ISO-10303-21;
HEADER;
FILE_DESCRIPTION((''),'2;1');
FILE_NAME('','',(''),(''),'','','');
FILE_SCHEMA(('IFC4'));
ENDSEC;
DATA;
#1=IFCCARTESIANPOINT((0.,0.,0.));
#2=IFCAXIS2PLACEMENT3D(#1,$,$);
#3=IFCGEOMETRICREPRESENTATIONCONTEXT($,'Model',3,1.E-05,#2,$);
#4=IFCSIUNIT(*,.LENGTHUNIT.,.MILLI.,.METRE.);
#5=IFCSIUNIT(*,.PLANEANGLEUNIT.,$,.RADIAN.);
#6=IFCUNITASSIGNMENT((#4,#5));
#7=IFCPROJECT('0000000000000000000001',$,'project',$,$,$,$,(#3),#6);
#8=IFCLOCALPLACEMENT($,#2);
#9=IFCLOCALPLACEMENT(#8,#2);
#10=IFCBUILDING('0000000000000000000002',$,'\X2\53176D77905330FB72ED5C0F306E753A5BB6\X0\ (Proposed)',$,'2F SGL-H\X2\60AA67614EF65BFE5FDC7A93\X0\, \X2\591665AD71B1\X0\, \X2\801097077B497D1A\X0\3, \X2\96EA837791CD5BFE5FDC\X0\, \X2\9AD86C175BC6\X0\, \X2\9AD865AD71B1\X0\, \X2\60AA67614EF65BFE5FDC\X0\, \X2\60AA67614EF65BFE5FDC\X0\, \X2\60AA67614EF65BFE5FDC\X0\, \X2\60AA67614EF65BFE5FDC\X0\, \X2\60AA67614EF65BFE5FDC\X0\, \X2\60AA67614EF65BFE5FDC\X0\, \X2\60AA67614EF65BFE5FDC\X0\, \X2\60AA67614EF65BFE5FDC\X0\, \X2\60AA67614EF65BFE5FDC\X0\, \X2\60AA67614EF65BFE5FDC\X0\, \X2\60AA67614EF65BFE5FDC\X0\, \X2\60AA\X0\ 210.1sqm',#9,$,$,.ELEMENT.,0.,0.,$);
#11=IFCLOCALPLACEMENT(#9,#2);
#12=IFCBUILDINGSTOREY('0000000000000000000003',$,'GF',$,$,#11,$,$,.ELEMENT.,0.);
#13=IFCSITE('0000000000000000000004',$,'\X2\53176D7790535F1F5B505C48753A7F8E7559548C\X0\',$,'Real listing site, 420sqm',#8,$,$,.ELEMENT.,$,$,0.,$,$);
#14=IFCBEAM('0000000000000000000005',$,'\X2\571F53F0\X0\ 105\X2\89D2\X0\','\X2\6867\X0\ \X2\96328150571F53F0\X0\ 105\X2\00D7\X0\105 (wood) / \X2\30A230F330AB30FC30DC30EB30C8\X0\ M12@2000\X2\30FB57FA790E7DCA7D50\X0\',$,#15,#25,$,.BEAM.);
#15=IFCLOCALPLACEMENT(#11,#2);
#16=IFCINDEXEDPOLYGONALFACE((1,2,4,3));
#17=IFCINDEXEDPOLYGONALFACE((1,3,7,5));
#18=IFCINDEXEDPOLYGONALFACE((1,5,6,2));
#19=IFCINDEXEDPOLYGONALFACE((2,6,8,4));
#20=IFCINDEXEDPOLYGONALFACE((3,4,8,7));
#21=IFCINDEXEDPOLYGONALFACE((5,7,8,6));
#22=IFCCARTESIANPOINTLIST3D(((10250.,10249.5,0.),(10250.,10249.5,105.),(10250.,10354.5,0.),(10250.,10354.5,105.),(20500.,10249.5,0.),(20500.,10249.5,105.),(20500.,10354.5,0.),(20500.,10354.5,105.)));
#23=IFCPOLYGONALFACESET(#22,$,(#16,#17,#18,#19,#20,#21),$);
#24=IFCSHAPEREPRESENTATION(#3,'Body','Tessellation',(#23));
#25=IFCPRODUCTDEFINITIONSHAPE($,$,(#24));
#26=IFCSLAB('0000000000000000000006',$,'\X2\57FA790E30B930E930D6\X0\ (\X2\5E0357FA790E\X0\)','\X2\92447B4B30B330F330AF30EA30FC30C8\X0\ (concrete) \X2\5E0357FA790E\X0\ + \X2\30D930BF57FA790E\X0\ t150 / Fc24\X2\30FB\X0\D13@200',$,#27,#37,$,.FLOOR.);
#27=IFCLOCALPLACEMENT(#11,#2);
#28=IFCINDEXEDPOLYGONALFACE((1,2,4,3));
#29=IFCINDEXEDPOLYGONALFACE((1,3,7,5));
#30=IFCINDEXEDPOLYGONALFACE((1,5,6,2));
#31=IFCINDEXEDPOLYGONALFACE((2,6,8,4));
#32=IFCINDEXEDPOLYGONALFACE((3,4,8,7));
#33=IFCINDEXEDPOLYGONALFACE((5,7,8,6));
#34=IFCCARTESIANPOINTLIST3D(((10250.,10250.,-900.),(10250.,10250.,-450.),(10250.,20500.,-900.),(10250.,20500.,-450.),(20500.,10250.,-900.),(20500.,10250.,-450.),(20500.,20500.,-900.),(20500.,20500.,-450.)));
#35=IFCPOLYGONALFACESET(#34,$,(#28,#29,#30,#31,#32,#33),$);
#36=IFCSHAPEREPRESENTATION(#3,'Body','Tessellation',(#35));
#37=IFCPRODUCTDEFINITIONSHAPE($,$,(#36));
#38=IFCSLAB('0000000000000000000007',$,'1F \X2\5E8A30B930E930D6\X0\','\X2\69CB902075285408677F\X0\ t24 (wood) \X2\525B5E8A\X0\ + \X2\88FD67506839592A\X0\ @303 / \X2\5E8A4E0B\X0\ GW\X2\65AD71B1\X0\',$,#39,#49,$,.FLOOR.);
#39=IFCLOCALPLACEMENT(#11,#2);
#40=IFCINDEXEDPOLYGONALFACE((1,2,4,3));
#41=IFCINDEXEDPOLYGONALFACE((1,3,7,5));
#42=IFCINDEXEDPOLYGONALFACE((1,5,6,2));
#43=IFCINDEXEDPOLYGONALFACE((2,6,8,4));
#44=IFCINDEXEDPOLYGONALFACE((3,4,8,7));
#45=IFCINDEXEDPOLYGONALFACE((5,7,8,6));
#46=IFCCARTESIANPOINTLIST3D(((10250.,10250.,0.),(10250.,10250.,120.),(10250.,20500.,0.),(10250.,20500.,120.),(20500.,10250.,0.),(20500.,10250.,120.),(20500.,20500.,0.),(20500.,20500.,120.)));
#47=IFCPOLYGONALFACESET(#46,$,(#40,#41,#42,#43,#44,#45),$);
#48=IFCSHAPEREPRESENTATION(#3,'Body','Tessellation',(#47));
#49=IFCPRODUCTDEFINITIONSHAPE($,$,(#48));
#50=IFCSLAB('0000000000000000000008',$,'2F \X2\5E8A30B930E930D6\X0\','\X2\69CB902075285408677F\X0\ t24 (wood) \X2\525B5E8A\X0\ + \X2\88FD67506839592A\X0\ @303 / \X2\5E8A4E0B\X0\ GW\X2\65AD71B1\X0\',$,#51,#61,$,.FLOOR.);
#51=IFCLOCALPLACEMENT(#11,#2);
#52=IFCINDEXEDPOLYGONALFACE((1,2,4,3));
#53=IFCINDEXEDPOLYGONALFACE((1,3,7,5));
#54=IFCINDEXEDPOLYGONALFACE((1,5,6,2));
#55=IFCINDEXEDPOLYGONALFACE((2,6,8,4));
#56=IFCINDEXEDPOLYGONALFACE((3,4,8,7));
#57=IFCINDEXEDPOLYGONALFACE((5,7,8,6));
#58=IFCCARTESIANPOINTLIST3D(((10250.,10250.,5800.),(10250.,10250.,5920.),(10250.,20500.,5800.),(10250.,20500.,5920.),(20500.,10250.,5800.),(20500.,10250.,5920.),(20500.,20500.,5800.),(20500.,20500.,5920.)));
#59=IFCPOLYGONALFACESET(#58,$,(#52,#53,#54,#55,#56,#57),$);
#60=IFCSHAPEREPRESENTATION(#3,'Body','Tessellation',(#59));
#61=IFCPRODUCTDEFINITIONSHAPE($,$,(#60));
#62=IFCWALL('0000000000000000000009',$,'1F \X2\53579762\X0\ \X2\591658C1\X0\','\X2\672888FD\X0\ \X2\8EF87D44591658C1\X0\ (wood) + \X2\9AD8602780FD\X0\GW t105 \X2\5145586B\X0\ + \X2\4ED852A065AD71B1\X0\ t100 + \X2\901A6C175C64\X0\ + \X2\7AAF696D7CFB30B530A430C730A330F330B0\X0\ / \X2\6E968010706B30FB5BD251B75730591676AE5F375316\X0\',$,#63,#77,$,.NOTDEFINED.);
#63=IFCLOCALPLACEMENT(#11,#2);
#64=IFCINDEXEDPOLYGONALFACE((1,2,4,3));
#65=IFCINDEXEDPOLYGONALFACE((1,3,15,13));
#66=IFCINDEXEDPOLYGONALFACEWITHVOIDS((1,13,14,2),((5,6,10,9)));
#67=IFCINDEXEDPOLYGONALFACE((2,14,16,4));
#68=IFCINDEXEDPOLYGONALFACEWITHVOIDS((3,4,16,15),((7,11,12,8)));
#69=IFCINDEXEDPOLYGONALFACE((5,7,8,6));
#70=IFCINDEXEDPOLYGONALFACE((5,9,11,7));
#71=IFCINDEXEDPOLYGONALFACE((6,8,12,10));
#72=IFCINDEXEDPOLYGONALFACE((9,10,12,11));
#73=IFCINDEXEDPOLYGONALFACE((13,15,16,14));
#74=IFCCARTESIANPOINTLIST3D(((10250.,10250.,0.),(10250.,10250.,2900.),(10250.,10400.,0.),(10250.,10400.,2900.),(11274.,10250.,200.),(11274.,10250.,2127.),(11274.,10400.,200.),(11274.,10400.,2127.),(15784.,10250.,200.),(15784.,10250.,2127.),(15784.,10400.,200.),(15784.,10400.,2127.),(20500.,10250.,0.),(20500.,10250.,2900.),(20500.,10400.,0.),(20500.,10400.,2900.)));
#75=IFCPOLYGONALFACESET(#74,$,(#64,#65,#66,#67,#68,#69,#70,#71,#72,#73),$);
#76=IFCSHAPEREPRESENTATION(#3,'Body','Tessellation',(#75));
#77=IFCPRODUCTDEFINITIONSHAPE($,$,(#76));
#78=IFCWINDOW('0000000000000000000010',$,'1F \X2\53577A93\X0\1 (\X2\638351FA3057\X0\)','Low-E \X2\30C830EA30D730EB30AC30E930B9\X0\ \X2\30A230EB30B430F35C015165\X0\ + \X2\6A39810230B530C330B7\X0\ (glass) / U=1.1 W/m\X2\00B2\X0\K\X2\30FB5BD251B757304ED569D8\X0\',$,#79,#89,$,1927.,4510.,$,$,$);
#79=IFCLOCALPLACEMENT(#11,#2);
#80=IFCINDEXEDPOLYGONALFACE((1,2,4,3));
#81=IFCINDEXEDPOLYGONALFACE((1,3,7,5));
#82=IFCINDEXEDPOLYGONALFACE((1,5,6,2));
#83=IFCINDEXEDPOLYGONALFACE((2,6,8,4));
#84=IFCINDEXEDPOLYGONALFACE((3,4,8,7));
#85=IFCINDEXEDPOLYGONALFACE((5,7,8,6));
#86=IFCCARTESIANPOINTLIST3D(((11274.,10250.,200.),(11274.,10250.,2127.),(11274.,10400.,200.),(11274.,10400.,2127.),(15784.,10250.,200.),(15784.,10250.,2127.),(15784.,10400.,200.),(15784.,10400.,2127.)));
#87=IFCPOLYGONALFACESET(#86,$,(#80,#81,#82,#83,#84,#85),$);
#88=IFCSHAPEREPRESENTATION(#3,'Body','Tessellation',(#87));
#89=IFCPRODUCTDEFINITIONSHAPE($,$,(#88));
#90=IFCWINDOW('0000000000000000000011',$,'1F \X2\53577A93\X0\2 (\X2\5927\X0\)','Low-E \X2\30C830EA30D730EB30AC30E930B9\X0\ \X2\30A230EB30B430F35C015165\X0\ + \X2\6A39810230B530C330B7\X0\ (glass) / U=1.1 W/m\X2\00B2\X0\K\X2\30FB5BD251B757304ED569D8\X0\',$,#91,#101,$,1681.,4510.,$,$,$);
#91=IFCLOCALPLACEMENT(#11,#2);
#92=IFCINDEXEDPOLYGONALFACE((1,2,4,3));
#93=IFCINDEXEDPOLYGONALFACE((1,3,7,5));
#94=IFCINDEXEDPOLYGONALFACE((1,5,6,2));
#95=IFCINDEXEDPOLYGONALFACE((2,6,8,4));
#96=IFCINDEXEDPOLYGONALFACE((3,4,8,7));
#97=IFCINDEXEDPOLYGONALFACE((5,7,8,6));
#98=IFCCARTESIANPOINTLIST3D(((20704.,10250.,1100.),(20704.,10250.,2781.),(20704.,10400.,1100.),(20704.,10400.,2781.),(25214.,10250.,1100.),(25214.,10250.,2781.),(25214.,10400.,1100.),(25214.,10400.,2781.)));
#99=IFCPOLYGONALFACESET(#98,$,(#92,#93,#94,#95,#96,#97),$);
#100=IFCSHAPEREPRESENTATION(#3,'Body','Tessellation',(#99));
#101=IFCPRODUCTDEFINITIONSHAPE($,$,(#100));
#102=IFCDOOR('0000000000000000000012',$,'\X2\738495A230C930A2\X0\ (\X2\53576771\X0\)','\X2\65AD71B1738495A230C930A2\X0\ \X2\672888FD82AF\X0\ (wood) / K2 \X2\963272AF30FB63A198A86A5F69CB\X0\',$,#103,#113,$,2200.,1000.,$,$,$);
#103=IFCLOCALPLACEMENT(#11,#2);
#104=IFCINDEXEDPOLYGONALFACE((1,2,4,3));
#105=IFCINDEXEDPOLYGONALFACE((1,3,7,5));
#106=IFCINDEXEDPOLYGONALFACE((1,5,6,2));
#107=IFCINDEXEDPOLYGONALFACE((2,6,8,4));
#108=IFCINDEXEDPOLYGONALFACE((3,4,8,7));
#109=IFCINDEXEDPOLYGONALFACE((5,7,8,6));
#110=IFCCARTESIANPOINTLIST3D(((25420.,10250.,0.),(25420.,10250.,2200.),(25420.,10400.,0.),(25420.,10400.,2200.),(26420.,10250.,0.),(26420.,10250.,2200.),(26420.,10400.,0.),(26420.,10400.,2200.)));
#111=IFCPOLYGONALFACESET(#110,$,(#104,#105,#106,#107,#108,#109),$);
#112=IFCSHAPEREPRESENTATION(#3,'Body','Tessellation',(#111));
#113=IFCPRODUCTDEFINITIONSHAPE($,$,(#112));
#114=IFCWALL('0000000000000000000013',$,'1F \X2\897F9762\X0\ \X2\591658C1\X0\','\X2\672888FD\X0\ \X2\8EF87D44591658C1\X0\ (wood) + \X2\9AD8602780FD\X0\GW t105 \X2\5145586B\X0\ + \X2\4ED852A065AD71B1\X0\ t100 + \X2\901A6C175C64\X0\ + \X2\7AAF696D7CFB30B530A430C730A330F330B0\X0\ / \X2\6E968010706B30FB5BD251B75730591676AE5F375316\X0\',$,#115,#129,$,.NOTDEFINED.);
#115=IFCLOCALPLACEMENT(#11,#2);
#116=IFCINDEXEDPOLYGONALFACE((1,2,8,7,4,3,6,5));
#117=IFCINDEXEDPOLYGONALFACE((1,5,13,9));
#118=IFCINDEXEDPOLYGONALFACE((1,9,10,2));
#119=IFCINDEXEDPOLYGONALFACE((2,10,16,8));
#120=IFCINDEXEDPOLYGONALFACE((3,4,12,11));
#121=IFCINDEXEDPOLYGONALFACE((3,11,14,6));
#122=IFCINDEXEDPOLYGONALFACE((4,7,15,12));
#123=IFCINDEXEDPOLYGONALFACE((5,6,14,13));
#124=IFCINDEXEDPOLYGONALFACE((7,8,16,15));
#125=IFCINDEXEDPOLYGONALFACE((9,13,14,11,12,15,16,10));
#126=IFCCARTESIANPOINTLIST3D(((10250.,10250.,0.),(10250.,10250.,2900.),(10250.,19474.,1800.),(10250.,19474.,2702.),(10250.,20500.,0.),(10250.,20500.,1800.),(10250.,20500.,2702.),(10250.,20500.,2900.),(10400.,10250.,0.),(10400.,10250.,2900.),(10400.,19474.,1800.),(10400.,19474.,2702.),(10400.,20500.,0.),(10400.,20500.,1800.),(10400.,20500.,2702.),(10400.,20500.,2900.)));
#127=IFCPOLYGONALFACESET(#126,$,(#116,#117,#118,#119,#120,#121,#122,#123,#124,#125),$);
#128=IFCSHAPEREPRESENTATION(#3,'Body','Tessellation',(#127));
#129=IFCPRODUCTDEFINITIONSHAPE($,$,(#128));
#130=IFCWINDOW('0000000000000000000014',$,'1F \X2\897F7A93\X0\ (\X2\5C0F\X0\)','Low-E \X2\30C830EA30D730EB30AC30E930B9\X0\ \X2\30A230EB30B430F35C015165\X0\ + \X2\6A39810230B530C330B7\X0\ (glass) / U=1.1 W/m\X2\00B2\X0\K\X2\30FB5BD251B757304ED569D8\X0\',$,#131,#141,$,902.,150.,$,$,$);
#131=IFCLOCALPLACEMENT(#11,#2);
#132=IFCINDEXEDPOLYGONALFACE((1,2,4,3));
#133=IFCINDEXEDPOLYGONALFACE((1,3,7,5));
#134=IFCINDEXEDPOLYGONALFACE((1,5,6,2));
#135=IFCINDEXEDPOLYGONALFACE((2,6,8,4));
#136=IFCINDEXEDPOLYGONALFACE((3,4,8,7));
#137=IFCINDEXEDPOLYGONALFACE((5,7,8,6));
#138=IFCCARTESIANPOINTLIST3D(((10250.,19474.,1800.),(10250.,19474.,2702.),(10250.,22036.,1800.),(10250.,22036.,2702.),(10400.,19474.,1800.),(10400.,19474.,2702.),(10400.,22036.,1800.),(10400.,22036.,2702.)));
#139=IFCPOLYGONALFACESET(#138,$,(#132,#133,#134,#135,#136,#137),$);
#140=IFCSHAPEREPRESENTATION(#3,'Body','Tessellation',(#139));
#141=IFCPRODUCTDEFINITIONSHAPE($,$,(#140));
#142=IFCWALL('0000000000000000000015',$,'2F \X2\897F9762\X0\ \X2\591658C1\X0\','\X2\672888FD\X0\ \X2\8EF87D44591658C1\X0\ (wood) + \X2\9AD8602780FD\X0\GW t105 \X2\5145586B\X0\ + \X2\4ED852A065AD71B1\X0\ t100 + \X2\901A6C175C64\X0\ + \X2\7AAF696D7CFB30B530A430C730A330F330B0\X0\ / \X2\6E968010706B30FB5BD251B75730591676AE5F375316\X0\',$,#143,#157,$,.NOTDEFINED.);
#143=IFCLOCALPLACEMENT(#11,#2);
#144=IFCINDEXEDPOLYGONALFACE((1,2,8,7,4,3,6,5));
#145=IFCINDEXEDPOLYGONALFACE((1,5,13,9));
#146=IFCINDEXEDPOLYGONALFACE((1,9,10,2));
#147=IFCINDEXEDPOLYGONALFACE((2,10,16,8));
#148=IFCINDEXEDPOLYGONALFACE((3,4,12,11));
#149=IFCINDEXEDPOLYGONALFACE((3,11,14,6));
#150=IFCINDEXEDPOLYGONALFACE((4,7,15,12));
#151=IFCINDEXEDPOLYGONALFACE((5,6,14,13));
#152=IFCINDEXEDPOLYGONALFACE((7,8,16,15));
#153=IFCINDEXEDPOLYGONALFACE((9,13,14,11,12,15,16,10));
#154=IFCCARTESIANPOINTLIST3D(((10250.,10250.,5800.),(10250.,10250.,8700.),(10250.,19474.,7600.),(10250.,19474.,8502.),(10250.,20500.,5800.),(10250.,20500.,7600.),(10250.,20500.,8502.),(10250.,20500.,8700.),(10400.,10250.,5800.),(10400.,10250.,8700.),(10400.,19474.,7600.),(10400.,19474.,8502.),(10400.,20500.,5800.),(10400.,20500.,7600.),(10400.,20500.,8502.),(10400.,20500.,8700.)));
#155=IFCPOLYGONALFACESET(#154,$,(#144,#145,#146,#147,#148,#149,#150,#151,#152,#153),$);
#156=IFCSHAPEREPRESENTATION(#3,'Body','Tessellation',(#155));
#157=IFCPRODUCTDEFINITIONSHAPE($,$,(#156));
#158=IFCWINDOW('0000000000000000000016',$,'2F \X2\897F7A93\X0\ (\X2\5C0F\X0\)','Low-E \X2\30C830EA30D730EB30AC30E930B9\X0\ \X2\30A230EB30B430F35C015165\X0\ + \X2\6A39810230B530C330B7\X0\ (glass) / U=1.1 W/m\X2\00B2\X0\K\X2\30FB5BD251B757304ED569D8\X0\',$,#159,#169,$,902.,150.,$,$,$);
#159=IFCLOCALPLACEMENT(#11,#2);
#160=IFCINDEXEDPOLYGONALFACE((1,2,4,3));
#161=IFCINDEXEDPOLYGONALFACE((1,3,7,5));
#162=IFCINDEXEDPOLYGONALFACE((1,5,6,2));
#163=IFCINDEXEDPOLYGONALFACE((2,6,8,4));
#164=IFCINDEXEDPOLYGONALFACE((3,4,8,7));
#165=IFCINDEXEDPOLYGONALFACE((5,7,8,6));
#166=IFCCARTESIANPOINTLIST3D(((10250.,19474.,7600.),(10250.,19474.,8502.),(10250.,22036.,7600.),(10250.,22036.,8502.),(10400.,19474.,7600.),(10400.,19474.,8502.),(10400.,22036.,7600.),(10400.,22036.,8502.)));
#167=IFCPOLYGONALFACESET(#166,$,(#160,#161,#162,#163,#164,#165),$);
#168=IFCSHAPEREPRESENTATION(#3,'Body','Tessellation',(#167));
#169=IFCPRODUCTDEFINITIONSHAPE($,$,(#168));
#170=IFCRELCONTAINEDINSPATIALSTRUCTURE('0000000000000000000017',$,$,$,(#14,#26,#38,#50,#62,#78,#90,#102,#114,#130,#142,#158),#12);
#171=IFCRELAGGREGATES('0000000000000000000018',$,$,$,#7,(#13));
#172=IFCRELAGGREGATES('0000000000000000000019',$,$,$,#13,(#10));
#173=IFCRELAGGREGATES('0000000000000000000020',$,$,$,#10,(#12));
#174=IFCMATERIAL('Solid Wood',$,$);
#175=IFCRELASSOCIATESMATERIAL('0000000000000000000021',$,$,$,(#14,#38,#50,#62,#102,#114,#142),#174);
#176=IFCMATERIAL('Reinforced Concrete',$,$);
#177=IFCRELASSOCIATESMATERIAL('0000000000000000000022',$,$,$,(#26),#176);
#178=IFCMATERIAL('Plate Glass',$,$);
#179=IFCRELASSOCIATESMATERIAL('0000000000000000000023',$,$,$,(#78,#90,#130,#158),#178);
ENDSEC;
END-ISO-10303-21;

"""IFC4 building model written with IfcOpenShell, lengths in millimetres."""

from ifc_helpers import new_model, si_unit, frame, frame_2d, origin, place, context, project, spatial, rectangle, extrude, material, element, fill, save


model = new_model("IFC4")

# Units and contexts
model_context = context("Model", 3, precision=1e-05, world=origin())
ifc_project = project(units=[si_unit("LENGTHUNIT", "METRE", prefix="MILLI"), si_unit("PLANEANGLEUNIT", "RADIAN")], contexts=[model_context])

# Site, building, storey
site_placement = place(None, origin())
site = spatial("IfcSite", under=ifc_project, at=site_placement, Name="北海道弟子屈町美留和", ObjectType="Real listing site, 420sqm", CompositionType="ELEMENT", RefElevation=0.0)
building_placement = place(site_placement, origin())
building = spatial("IfcBuilding", under=site, at=building_placement, Name="北海道・狭小の町家 (Proposed)", ObjectType="2F SGL-H悪条件対応窓, 外断熱, 耐震等級3, 雪荷重対応, 高気密, 高断熱, 悪条件対応, 悪条件対応, 悪条件対応, 悪条件対応, 悪条件対応, 悪条件対応, 悪条件対応, 悪条件対応, 悪条件対応, 悪条件対応, 悪条件対応, 悪 210.1sqm", CompositionType="ELEMENT", ElevationOfRefHeight=0.0, ElevationOfTerrain=0.0)
storey_placement = place(building_placement, origin())
storey = spatial("IfcBuildingStorey", under=building, at=storey_placement, Name="GF", CompositionType="ELEMENT", Elevation=0.0)

# Shared definitions
ifc_material_1 = material(Name="Solid Wood")

# Beam
beam_placement = place(storey_placement, frame((5125.0, 5125.0, 0.0)))
element("IfcBeam", 1, at=beam_placement, inside=storey, material=ifc_material_1, Name="土台 105角", Description="桧 防腐土台 105×105 (wood) / アンカーボルト M12@2000・基礎緊結", PredefinedType="BEAM", context=model_context, shape_type="SweptSolid", body=[
    extrude(rectangle(XDim=10250.0, YDim=105.0, at=frame_2d((5125.0, 52.0))), frame((5125.0, 5125.0, 0.0)), (0.0, 0.0, 1.0), 105.0),
])

# Slabs
ifc_material_2 = material(Name="Reinforced Concrete")
slab_1_placement = place(storey_placement, frame((5125.0, 5125.0, -450.0)))
element("IfcSlab", 2, at=slab_1_placement, inside=storey, material=ifc_material_2, Name="基礎スラブ (布基礎)", Description="鉄筋コンクリート (concrete) 布基礎 + ベタ基礎 t150 / Fc24・D13@200", PredefinedType="FLOOR", context=model_context, shape_type="SweptSolid", body=[
    extrude(rectangle(XDim=10250.0, YDim=10250.0, at=frame_2d((5125.0, 5125.0))), frame((5125.0, 5125.0, -450.0)), (0.0, 0.0, 1.0), 450.0),
])
slab_2_placement = place(storey_placement, frame((5125.0, 5125.0, 0.0)))
element("IfcSlab", 3, at=slab_2_placement, inside=storey, material=ifc_material_1, Name="1F 床スラブ", Description="構造用合板 t24 (wood) 剛床 + 製材根太 @303 / 床下 GW断熱", PredefinedType="FLOOR", context=model_context, shape_type="SweptSolid", body=[
    extrude(rectangle(XDim=10250.0, YDim=10250.0, at=frame_2d((5125.0, 5125.0))), frame((5125.0, 5125.0, 0.0)), (0.0, 0.0, 1.0), 120.0),
])
slab_3_placement = place(storey_placement, frame((5125.0, 5125.0, 2900.0)))
element("IfcSlab", 4, at=slab_3_placement, inside=storey, material=ifc_material_1, Name="2F 床スラブ", Description="構造用合板 t24 (wood) 剛床 + 製材根太 @303 / 床下 GW断熱", PredefinedType="FLOOR", context=model_context, shape_type="SweptSolid", body=[
    extrude(rectangle(XDim=10250.0, YDim=10250.0, at=frame_2d((5125.0, 5125.0))), frame((5125.0, 5125.0, 2900.0)), (0.0, 0.0, 1.0), 120.0),
])

# Wall, openings, windows, door
wall_1_placement = place(storey_placement, frame((5125.0, 5125.0, 0.0)))
wall_1 = element("IfcWall", 5, at=wall_1_placement, inside=storey, material=ifc_material_1, Name="1F 南面 外壁", Description="木製 軸組外壁 (wood) + 高性能GW t105 充填 + 付加断熱 t100 + 通気層 + 窯業系サイディング / 準耐火・寒冷地外皮強化", PredefinedType="NOTDEFINED", context=model_context, shape_type="SweptSolid", body=[
    extrude(rectangle(XDim=10250.0, YDim=150.0, at=frame_2d((5125.0, 75.0))), frame((5125.0, 5125.0, 0.0)), (0.0, 0.0, 1.0), 2900.0),
])
opening_1_placement = place(storey_placement, frame((5637.0, 5125.0, 100.0)))
opening_1 = element("IfcOpeningElement", 6, at=opening_1_placement, cuts=wall_1, PredefinedType="NOTDEFINED", context=model_context, shape_type="SweptSolid", body=[
    extrude(rectangle(XDim=4510.0, YDim=150.0, at=frame_2d((2255.0, 75.0))), frame((5637.0, 5125.0, 100.0)), (0.0, 0.0, 1.0), 1927.0),
])
opening_2_placement = place(storey_placement, frame((10352.0, 5125.0, 550.0)))
opening_2 = element("IfcOpeningElement", 7, at=opening_2_placement, cuts=wall_1, PredefinedType="NOTDEFINED", context=model_context, shape_type="SweptSolid", body=[
    extrude(rectangle(XDim=4510.0, YDim=150.0, at=frame_2d((2255.0, 75.0))), frame((10352.0, 5125.0, 550.0)), (0.0, 0.0, 1.0), 1681.0),
])
opening_3_placement = place(storey_placement, frame((12710.0, 5125.0, 0.0)))
opening_3 = element("IfcOpeningElement", 8, at=opening_3_placement, cuts=wall_1, PredefinedType="NOTDEFINED", context=model_context, shape_type="SweptSolid", body=[
    extrude(rectangle(XDim=1000.0, YDim=150.0, at=frame_2d((500.0, 75.0))), frame((12710.0, 5125.0, 0.0)), (0.0, 0.0, 1.0), 2200.0),
])
ifc_material_3 = material(Name="Plate Glass")
window_1_placement = place(storey_placement, frame((5637.0, 5125.0, 100.0)))
window_1 = element("IfcWindow", 9, at=window_1_placement, inside=storey, material=ifc_material_3, Name="1F 南窓1 (掃出し)", Description="Low-E トリプルガラス アルゴン封入 + 樹脂サッシ (glass) / U=1.1 W/m²K・寒冷地仕様", OverallHeight=1927.0, OverallWidth=4510.0, context=model_context, shape_type="SweptSolid", body=[
    extrude(rectangle(XDim=4510.0, YDim=150.0, at=frame_2d((2255.0, 75.0))), frame((5637.0, 5125.0, 100.0)), (0.0, 0.0, 1.0), 1927.0),
])
fill(opening_1, window_1)
window_2_placement = place(storey_placement, frame((10352.0, 5125.0, 550.0)))
window_2 = element("IfcWindow", 10, at=window_2_placement, inside=storey, material=ifc_material_3, Name="1F 南窓2 (大)", Description="Low-E トリプルガラス アルゴン封入 + 樹脂サッシ (glass) / U=1.1 W/m²K・寒冷地仕様", OverallHeight=1681.0, OverallWidth=4510.0, context=model_context, shape_type="SweptSolid", body=[
    extrude(rectangle(XDim=4510.0, YDim=150.0, at=frame_2d((2255.0, 75.0))), frame((10352.0, 5125.0, 550.0)), (0.0, 0.0, 1.0), 1681.0),
])
fill(opening_2, window_2)
door_placement = place(storey_placement, frame((12710.0, 5125.0, 0.0)))
door = element("IfcDoor", 11, at=door_placement, inside=storey, material=ifc_material_1, Name="玄関ドア (南東)", Description="断熱玄関ドア 木製芯 (wood) / K2 防犯・採風機構", OverallHeight=2200.0, OverallWidth=1000.0, context=model_context, shape_type="SweptSolid", body=[
    extrude(rectangle(XDim=1000.0, YDim=150.0, at=frame_2d((500.0, 75.0))), frame((12710.0, 5125.0, 0.0)), (0.0, 0.0, 1.0), 2200.0),
])
fill(opening_3, door)

# Wall, opening, window
wall_2_placement = place(storey_placement, frame((5125.0, 5125.0, 0.0)))
wall_2 = element("IfcWall", 12, at=wall_2_placement, inside=storey, material=ifc_material_1, Name="1F 西面 外壁", Description="木製 軸組外壁 (wood) + 高性能GW t105 充填 + 付加断熱 t100 + 通気層 + 窯業系サイディング / 準耐火・寒冷地外皮強化", PredefinedType="NOTDEFINED", context=model_context, shape_type="SweptSolid", body=[
    extrude(rectangle(XDim=150.0, YDim=10250.0, at=frame_2d((75.0, 5125.0))), frame((5125.0, 5125.0, 0.0)), (0.0, 0.0, 1.0), 2900.0),
])
opening_4_placement = place(storey_placement, frame((5125.0, 9737.0, 900.0)))
opening_4 = element("IfcOpeningElement", 13, at=opening_4_placement, cuts=wall_2, PredefinedType="NOTDEFINED", context=model_context, shape_type="SweptSolid", body=[
    extrude(rectangle(XDim=150.0, YDim=2562.0, at=frame_2d((75.0, 1281.0))), frame((5125.0, 9737.0, 900.0)), (0.0, 0.0, 1.0), 902.0),
])
window_3_placement = place(storey_placement, frame((5125.0, 9737.0, 900.0)))
window_3 = element("IfcWindow", 14, at=window_3_placement, inside=storey, material=ifc_material_3, Name="1F 西窓 (小)", Description="Low-E トリプルガラス アルゴン封入 + 樹脂サッシ (glass) / U=1.1 W/m²K・寒冷地仕様", OverallHeight=902.0, OverallWidth=150.0, context=model_context, shape_type="SweptSolid", body=[
    extrude(rectangle(XDim=150.0, YDim=2562.0, at=frame_2d((75.0, 1281.0))), frame((5125.0, 9737.0, 900.0)), (0.0, 0.0, 1.0), 902.0),
])
fill(opening_4, window_3)

# Wall, opening, window
wall_3_placement = place(storey_placement, frame((5125.0, 5125.0, 2900.0)))
wall_3 = element("IfcWall", 15, at=wall_3_placement, inside=storey, material=ifc_material_1, Name="2F 西面 外壁", Description="木製 軸組外壁 (wood) + 高性能GW t105 充填 + 付加断熱 t100 + 通気層 + 窯業系サイディング / 準耐火・寒冷地外皮強化", PredefinedType="NOTDEFINED", context=model_context, shape_type="SweptSolid", body=[
    extrude(rectangle(XDim=150.0, YDim=10250.0, at=frame_2d((75.0, 5125.0))), frame((5125.0, 5125.0, 2900.0)), (0.0, 0.0, 1.0), 2900.0),
])
opening_5_placement = place(storey_placement, frame((5125.0, 9737.0, 3800.0)))
opening_5 = element("IfcOpeningElement", 16, at=opening_5_placement, cuts=wall_3, PredefinedType="NOTDEFINED", context=model_context, shape_type="SweptSolid", body=[
    extrude(rectangle(XDim=150.0, YDim=2562.0, at=frame_2d((75.0, 1281.0))), frame((5125.0, 9737.0, 3800.0)), (0.0, 0.0, 1.0), 902.0),
])
window_4_placement = place(storey_placement, frame((5125.0, 9737.0, 3800.0)))
window_4 = element("IfcWindow", 17, at=window_4_placement, inside=storey, material=ifc_material_3, Name="2F 西窓 (小)", Description="Low-E トリプルガラス アルゴン封入 + 樹脂サッシ (glass) / U=1.1 W/m²K・寒冷地仕様", OverallHeight=902.0, OverallWidth=150.0, context=model_context, shape_type="SweptSolid", body=[
    extrude(rectangle(XDim=150.0, YDim=2562.0, at=frame_2d((75.0, 1281.0))), frame((5125.0, 9737.0, 3800.0)), (0.0, 0.0, 1.0), 902.0),
])
fill(opening_5, window_4)

save(model, "model.ifc")
